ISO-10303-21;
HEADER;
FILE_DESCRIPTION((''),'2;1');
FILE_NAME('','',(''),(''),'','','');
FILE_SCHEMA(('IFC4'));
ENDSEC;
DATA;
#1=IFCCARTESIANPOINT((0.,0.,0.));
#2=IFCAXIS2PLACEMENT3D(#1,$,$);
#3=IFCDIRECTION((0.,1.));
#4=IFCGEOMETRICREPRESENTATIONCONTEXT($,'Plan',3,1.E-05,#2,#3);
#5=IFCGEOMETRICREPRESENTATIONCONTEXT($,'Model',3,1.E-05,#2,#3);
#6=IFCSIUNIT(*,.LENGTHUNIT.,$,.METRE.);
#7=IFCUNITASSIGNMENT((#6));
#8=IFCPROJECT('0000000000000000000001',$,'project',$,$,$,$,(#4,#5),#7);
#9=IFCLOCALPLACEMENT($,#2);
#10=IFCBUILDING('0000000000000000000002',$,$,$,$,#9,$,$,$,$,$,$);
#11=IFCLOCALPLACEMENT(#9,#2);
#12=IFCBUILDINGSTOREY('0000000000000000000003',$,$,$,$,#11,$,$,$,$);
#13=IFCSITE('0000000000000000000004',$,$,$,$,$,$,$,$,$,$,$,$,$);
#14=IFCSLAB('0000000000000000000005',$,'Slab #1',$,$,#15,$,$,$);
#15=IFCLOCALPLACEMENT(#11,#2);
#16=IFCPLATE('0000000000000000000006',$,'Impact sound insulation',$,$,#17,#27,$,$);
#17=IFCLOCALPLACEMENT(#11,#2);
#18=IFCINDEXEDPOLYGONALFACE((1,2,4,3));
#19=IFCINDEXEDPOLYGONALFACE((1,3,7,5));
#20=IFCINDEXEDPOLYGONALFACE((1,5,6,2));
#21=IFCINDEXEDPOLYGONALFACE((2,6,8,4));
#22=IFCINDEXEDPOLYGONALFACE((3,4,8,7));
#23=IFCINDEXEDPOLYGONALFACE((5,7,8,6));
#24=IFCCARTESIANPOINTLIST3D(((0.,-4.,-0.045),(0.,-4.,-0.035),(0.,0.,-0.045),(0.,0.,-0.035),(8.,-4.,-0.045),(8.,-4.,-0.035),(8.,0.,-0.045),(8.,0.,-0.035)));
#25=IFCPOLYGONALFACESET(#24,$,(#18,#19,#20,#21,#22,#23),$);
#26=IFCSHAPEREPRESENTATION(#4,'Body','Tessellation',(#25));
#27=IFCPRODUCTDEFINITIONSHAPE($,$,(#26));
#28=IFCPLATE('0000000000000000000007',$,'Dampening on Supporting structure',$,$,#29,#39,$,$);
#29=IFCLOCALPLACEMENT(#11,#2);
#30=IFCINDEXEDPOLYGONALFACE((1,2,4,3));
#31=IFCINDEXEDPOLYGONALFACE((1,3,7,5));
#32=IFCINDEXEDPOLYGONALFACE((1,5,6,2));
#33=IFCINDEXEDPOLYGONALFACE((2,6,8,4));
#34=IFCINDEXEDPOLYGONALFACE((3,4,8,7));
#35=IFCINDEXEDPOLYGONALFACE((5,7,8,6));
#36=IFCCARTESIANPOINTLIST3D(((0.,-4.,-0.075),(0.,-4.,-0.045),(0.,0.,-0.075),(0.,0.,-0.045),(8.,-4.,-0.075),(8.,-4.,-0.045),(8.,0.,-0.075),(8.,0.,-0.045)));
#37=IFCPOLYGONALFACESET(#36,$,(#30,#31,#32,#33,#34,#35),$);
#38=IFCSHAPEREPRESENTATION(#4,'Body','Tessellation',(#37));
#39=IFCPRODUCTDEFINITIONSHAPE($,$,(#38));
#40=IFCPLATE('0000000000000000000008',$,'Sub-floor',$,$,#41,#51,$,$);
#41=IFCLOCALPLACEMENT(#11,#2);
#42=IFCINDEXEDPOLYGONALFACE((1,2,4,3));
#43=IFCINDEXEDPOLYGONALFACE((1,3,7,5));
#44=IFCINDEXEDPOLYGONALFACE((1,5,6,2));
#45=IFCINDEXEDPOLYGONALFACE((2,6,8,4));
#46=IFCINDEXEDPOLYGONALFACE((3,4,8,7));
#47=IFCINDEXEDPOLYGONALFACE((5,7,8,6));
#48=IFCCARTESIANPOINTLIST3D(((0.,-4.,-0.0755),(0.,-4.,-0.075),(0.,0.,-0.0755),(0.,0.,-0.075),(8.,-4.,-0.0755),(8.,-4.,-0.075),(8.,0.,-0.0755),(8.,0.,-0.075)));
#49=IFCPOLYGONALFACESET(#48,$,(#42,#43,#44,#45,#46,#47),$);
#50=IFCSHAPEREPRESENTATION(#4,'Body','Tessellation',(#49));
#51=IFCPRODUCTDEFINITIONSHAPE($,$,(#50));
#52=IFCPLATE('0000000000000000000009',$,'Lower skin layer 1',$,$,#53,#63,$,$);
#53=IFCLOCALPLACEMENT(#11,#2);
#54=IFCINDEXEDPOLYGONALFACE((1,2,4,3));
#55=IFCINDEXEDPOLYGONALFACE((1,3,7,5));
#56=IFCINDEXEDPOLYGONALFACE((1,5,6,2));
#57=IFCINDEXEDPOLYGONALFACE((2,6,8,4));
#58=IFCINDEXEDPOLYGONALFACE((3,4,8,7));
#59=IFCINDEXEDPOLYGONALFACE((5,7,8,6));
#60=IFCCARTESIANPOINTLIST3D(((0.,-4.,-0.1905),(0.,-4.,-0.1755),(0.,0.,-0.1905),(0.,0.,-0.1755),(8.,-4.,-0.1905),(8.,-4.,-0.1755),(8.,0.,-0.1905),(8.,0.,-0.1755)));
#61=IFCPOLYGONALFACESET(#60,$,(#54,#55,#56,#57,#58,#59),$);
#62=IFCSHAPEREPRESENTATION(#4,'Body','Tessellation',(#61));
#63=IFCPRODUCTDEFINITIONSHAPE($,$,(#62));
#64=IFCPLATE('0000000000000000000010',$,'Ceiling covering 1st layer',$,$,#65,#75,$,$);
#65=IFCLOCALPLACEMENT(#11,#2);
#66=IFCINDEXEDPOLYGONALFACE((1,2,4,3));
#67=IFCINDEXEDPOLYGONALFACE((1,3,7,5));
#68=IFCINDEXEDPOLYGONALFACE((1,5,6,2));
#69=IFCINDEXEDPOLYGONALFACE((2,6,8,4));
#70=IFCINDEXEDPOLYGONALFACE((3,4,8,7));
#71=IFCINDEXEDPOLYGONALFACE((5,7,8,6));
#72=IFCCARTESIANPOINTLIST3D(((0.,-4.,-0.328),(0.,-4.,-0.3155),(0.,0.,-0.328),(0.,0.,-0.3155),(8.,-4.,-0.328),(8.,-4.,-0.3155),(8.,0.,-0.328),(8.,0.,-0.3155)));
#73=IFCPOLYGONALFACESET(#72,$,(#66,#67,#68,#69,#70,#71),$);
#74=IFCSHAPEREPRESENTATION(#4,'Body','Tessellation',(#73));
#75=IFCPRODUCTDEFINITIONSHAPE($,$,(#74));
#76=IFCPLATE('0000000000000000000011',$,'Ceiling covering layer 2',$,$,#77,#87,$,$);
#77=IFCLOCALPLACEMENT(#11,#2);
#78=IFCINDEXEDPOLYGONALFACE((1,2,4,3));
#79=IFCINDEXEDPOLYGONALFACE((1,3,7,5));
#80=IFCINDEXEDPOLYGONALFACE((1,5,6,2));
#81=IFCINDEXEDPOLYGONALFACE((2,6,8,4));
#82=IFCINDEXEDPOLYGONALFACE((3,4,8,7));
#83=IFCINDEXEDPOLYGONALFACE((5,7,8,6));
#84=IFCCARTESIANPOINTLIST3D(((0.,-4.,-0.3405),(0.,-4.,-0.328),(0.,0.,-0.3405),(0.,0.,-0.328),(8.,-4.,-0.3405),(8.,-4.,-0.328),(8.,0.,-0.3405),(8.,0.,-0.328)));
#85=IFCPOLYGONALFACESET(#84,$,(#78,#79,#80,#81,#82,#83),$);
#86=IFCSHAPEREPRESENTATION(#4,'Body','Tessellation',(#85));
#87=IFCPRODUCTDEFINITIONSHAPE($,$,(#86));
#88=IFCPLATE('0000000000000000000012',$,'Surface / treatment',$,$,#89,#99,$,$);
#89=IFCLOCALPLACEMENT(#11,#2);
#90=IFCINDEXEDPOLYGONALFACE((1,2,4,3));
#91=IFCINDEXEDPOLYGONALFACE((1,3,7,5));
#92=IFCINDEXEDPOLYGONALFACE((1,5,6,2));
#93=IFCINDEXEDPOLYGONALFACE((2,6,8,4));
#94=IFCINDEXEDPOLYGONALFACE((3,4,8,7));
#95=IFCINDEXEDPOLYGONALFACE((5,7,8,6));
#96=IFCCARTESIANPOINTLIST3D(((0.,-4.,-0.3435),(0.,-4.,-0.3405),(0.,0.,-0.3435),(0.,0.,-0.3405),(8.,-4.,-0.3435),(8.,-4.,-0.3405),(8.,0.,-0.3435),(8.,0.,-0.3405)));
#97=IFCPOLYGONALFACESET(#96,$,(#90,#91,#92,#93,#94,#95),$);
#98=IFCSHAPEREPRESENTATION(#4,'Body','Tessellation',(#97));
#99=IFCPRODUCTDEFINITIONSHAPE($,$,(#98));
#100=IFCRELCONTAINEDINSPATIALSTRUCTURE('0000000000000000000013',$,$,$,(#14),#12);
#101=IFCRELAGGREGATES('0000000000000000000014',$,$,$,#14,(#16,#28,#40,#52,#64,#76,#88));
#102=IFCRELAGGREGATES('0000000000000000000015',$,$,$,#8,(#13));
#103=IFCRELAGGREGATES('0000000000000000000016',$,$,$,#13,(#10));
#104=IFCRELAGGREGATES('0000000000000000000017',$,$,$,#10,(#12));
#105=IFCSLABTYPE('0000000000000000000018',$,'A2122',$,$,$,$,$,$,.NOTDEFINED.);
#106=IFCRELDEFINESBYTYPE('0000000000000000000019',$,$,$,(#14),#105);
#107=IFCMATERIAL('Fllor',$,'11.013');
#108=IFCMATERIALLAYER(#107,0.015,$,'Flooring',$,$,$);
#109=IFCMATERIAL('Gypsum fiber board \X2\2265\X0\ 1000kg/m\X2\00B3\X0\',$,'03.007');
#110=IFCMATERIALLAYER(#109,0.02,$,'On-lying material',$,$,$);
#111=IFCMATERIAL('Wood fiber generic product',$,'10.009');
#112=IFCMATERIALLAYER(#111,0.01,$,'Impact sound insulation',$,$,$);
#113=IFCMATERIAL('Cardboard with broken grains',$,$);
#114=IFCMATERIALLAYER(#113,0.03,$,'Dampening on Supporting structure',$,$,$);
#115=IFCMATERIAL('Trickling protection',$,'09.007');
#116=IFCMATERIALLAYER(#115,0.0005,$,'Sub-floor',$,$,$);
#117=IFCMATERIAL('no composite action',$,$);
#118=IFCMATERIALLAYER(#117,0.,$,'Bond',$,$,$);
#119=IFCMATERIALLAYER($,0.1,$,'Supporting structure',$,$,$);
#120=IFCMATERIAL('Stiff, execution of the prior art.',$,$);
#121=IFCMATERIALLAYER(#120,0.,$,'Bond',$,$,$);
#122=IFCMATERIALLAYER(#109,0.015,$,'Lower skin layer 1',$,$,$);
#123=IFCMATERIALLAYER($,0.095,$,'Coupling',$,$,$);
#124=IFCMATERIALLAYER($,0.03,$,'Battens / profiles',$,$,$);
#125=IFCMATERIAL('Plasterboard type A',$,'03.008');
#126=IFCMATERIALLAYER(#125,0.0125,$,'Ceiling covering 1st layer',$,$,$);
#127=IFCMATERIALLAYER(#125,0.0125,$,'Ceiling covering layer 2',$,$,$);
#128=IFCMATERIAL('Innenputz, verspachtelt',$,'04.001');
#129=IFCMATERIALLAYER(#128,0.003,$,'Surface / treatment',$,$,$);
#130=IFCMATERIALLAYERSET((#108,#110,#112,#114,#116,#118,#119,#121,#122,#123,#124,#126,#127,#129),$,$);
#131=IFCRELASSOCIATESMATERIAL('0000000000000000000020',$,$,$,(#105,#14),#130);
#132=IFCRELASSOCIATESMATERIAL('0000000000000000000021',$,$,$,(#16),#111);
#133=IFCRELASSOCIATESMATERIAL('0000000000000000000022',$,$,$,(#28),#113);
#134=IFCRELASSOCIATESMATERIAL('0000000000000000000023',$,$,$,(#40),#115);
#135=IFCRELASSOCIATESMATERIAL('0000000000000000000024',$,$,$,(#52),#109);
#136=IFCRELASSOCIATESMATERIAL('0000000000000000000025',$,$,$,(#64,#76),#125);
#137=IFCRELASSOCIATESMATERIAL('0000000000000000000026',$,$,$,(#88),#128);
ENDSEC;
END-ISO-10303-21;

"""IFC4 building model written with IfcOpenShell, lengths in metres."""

from ifc_helpers import new_model, si_unit, direction, frame, frame_2d, origin, place, context, project, spatial, rectangle, extrude, material, layer, layer_set, type_object, element, aggregate, save


model = new_model("IFC4")

# Units and contexts
plan_context = context("Plan", 3, precision=1e-05, world=origin(), true_north=direction((0.0, 1.0)))
model_context = context("Model", 3, precision=1e-05, world=origin(), true_north=direction((0.0, 1.0)))
ifc_project = project(units=[si_unit("LENGTHUNIT", "METRE")], contexts=[plan_context, model_context])

# Site, building, storey
site = spatial("IfcSite", under=ifc_project)
building_placement = place(None, origin())
building = spatial("IfcBuilding", under=site, at=building_placement)
storey_placement = place(building_placement, origin())
storey = spatial("IfcBuildingStorey", under=building, at=storey_placement)

# Slab, plates
ifc_material_1 = material(Name="Fllor", Category="11.013")
ifc_layer_1 = layer(ifc_material_1, 0.015, Name="Flooring")
ifc_material_2 = material(Name="Gypsum fiber board ≥ 1000kg/m³", Category="03.007")
ifc_layer_2 = layer(ifc_material_2, 0.02, Name="On-lying material")
ifc_material_3 = material(Name="Wood fiber generic product", Category="10.009")
ifc_layer_3 = layer(ifc_material_3, 0.01, Name="Impact sound insulation")
ifc_material_4 = material(Name="Cardboard with broken grains")
ifc_layer_4 = layer(ifc_material_4, 0.03, Name="Dampening on Supporting structure")
ifc_material_5 = material(Name="Trickling protection", Category="09.007")
ifc_layer_5 = layer(ifc_material_5, 0.0005, Name="Sub-floor")
ifc_material_6 = material(Name="no composite action")
ifc_layer_6 = layer(ifc_material_6, 0.0, Name="Bond")
ifc_layer_7 = layer(None, 0.1, Name="Supporting structure")
ifc_material_7 = material(Name="Stiff, execution of the prior art.")
ifc_layer_8 = layer(ifc_material_7, 0.0, Name="Bond")
ifc_layer_9 = layer(ifc_material_2, 0.015, Name="Lower skin layer 1")
ifc_layer_10 = layer(None, 0.095, Name="Coupling")
ifc_layer_11 = layer(None, 0.03, Name="Battens / profiles")
ifc_material_8 = material(Name="Plasterboard type A", Category="03.008")
ifc_layer_12 = layer(ifc_material_8, 0.0125, Name="Ceiling covering 1st layer")
ifc_layer_13 = layer(ifc_material_8, 0.0125, Name="Ceiling covering layer 2")
ifc_material_9 = material(Name="Innenputz, verspachtelt", Category="04.001")
ifc_layer_14 = layer(ifc_material_9, 0.003, Name="Surface / treatment")
ifc_layer_set = layer_set([ifc_layer_1, ifc_layer_2, ifc_layer_3, ifc_layer_4, ifc_layer_5, ifc_layer_6, ifc_layer_7, ifc_layer_8, ifc_layer_9, ifc_layer_10, ifc_layer_11, ifc_layer_12, ifc_layer_13, ifc_layer_14])
slab_type = type_object("IfcSlabType", Name="A2122", PredefinedType="NOTDEFINED", material=ifc_layer_set)
slab_placement = place(None, frame((0.0, 0.0, 0.0), z_axis=(0.0, 0.0, -1.0), x_axis=(1.0, 0.0, 0.0)))
slab = element("IfcSlab", 1, at=slab_placement, inside=storey, type_object=slab_type, material=ifc_layer_set, Name="Slab #1")
plate_1_placement = place(slab_placement, origin())
plate_1 = element("IfcPlate", 2, at=plate_1_placement, material=ifc_material_3, Name="Impact sound insulation", context=plan_context, shape_type="SweptSolid", body=[
    extrude(rectangle(XDim=8.0, YDim=4.0, at=frame_2d((4.0, 2.0), x_axis=(1.0, 0.0))), frame((0.0, 0.0, 0.035), z_axis=(0.0, 0.0, 1.0), x_axis=(1.0, 0.0, 0.0)), (0.0, 0.0, 1.0), 0.01),
])
plate_2_placement = place(slab_placement, origin())
plate_2 = element("IfcPlate", 3, at=plate_2_placement, material=ifc_material_4, Name="Dampening on Supporting structure", context=plan_context, shape_type="SweptSolid", body=[
    extrude(rectangle(XDim=8.0, YDim=4.0, at=frame_2d((4.0, 2.0), x_axis=(1.0, 0.0))), frame((0.0, 0.0, 0.045), z_axis=(0.0, 0.0, 1.0), x_axis=(1.0, 0.0, 0.0)), (0.0, 0.0, 1.0), 0.03),
])
plate_3_placement = place(slab_placement, origin())
plate_3 = element("IfcPlate", 4, at=plate_3_placement, material=ifc_material_5, Name="Sub-floor", context=plan_context, shape_type="SweptSolid", body=[
    extrude(rectangle(XDim=8.0, YDim=4.0, at=frame_2d((4.0, 2.0), x_axis=(1.0, 0.0))), frame((0.0, 0.0, 0.075), z_axis=(0.0, 0.0, 1.0), x_axis=(1.0, 0.0, 0.0)), (0.0, 0.0, 1.0), 0.0005),
])
plate_4_placement = place(slab_placement, origin())
plate_4 = element("IfcPlate", 5, at=plate_4_placement, material=ifc_material_2, Name="Lower skin layer 1", context=plan_context, shape_type="SweptSolid", body=[
    extrude(rectangle(XDim=8.0, YDim=4.0, at=frame_2d((4.0, 2.0), x_axis=(1.0, 0.0))), frame((0.0, 0.0, 0.1755), z_axis=(0.0, 0.0, 1.0), x_axis=(1.0, 0.0, 0.0)), (0.0, 0.0, 1.0), 0.015),
])
plate_5_placement = place(slab_placement, origin())
plate_5 = element("IfcPlate", 6, at=plate_5_placement, material=ifc_material_8, Name="Ceiling covering 1st layer", context=plan_context, shape_type="SweptSolid", body=[
    extrude(rectangle(XDim=8.0, YDim=4.0, at=frame_2d((4.0, 2.0), x_axis=(1.0, 0.0))), frame((0.0, 0.0, 0.3155), z_axis=(0.0, 0.0, 1.0), x_axis=(1.0, 0.0, 0.0)), (0.0, 0.0, 1.0), 0.0125),
])
plate_6_placement = place(slab_placement, origin())
plate_6 = element("IfcPlate", 7, at=plate_6_placement, material=ifc_material_8, Name="Ceiling covering layer 2", context=plan_context, shape_type="SweptSolid", body=[
    extrude(rectangle(XDim=8.0, YDim=4.0, at=frame_2d((4.0, 2.0), x_axis=(1.0, 0.0))), frame((0.0, 0.0, 0.328), z_axis=(0.0, 0.0, 1.0), x_axis=(1.0, 0.0, 0.0)), (0.0, 0.0, 1.0), 0.0125),
])
plate_7_placement = place(slab_placement, origin())
plate_7 = element("IfcPlate", 8, at=plate_7_placement, material=ifc_material_9, Name="Surface / treatment", context=plan_context, shape_type="SweptSolid", body=[
    extrude(rectangle(XDim=8.0, YDim=4.0, at=frame_2d((4.0, 2.0), x_axis=(1.0, 0.0))), frame((0.0, 0.0, 0.3405), z_axis=(0.0, 0.0, 1.0), x_axis=(1.0, 0.0, 0.0)), (0.0, 0.0, 1.0), 0.003),
])
aggregate(slab, [plate_1, plate_2, plate_3, plate_4, plate_5, plate_6, plate_7])

save(model, "model.ifc")
